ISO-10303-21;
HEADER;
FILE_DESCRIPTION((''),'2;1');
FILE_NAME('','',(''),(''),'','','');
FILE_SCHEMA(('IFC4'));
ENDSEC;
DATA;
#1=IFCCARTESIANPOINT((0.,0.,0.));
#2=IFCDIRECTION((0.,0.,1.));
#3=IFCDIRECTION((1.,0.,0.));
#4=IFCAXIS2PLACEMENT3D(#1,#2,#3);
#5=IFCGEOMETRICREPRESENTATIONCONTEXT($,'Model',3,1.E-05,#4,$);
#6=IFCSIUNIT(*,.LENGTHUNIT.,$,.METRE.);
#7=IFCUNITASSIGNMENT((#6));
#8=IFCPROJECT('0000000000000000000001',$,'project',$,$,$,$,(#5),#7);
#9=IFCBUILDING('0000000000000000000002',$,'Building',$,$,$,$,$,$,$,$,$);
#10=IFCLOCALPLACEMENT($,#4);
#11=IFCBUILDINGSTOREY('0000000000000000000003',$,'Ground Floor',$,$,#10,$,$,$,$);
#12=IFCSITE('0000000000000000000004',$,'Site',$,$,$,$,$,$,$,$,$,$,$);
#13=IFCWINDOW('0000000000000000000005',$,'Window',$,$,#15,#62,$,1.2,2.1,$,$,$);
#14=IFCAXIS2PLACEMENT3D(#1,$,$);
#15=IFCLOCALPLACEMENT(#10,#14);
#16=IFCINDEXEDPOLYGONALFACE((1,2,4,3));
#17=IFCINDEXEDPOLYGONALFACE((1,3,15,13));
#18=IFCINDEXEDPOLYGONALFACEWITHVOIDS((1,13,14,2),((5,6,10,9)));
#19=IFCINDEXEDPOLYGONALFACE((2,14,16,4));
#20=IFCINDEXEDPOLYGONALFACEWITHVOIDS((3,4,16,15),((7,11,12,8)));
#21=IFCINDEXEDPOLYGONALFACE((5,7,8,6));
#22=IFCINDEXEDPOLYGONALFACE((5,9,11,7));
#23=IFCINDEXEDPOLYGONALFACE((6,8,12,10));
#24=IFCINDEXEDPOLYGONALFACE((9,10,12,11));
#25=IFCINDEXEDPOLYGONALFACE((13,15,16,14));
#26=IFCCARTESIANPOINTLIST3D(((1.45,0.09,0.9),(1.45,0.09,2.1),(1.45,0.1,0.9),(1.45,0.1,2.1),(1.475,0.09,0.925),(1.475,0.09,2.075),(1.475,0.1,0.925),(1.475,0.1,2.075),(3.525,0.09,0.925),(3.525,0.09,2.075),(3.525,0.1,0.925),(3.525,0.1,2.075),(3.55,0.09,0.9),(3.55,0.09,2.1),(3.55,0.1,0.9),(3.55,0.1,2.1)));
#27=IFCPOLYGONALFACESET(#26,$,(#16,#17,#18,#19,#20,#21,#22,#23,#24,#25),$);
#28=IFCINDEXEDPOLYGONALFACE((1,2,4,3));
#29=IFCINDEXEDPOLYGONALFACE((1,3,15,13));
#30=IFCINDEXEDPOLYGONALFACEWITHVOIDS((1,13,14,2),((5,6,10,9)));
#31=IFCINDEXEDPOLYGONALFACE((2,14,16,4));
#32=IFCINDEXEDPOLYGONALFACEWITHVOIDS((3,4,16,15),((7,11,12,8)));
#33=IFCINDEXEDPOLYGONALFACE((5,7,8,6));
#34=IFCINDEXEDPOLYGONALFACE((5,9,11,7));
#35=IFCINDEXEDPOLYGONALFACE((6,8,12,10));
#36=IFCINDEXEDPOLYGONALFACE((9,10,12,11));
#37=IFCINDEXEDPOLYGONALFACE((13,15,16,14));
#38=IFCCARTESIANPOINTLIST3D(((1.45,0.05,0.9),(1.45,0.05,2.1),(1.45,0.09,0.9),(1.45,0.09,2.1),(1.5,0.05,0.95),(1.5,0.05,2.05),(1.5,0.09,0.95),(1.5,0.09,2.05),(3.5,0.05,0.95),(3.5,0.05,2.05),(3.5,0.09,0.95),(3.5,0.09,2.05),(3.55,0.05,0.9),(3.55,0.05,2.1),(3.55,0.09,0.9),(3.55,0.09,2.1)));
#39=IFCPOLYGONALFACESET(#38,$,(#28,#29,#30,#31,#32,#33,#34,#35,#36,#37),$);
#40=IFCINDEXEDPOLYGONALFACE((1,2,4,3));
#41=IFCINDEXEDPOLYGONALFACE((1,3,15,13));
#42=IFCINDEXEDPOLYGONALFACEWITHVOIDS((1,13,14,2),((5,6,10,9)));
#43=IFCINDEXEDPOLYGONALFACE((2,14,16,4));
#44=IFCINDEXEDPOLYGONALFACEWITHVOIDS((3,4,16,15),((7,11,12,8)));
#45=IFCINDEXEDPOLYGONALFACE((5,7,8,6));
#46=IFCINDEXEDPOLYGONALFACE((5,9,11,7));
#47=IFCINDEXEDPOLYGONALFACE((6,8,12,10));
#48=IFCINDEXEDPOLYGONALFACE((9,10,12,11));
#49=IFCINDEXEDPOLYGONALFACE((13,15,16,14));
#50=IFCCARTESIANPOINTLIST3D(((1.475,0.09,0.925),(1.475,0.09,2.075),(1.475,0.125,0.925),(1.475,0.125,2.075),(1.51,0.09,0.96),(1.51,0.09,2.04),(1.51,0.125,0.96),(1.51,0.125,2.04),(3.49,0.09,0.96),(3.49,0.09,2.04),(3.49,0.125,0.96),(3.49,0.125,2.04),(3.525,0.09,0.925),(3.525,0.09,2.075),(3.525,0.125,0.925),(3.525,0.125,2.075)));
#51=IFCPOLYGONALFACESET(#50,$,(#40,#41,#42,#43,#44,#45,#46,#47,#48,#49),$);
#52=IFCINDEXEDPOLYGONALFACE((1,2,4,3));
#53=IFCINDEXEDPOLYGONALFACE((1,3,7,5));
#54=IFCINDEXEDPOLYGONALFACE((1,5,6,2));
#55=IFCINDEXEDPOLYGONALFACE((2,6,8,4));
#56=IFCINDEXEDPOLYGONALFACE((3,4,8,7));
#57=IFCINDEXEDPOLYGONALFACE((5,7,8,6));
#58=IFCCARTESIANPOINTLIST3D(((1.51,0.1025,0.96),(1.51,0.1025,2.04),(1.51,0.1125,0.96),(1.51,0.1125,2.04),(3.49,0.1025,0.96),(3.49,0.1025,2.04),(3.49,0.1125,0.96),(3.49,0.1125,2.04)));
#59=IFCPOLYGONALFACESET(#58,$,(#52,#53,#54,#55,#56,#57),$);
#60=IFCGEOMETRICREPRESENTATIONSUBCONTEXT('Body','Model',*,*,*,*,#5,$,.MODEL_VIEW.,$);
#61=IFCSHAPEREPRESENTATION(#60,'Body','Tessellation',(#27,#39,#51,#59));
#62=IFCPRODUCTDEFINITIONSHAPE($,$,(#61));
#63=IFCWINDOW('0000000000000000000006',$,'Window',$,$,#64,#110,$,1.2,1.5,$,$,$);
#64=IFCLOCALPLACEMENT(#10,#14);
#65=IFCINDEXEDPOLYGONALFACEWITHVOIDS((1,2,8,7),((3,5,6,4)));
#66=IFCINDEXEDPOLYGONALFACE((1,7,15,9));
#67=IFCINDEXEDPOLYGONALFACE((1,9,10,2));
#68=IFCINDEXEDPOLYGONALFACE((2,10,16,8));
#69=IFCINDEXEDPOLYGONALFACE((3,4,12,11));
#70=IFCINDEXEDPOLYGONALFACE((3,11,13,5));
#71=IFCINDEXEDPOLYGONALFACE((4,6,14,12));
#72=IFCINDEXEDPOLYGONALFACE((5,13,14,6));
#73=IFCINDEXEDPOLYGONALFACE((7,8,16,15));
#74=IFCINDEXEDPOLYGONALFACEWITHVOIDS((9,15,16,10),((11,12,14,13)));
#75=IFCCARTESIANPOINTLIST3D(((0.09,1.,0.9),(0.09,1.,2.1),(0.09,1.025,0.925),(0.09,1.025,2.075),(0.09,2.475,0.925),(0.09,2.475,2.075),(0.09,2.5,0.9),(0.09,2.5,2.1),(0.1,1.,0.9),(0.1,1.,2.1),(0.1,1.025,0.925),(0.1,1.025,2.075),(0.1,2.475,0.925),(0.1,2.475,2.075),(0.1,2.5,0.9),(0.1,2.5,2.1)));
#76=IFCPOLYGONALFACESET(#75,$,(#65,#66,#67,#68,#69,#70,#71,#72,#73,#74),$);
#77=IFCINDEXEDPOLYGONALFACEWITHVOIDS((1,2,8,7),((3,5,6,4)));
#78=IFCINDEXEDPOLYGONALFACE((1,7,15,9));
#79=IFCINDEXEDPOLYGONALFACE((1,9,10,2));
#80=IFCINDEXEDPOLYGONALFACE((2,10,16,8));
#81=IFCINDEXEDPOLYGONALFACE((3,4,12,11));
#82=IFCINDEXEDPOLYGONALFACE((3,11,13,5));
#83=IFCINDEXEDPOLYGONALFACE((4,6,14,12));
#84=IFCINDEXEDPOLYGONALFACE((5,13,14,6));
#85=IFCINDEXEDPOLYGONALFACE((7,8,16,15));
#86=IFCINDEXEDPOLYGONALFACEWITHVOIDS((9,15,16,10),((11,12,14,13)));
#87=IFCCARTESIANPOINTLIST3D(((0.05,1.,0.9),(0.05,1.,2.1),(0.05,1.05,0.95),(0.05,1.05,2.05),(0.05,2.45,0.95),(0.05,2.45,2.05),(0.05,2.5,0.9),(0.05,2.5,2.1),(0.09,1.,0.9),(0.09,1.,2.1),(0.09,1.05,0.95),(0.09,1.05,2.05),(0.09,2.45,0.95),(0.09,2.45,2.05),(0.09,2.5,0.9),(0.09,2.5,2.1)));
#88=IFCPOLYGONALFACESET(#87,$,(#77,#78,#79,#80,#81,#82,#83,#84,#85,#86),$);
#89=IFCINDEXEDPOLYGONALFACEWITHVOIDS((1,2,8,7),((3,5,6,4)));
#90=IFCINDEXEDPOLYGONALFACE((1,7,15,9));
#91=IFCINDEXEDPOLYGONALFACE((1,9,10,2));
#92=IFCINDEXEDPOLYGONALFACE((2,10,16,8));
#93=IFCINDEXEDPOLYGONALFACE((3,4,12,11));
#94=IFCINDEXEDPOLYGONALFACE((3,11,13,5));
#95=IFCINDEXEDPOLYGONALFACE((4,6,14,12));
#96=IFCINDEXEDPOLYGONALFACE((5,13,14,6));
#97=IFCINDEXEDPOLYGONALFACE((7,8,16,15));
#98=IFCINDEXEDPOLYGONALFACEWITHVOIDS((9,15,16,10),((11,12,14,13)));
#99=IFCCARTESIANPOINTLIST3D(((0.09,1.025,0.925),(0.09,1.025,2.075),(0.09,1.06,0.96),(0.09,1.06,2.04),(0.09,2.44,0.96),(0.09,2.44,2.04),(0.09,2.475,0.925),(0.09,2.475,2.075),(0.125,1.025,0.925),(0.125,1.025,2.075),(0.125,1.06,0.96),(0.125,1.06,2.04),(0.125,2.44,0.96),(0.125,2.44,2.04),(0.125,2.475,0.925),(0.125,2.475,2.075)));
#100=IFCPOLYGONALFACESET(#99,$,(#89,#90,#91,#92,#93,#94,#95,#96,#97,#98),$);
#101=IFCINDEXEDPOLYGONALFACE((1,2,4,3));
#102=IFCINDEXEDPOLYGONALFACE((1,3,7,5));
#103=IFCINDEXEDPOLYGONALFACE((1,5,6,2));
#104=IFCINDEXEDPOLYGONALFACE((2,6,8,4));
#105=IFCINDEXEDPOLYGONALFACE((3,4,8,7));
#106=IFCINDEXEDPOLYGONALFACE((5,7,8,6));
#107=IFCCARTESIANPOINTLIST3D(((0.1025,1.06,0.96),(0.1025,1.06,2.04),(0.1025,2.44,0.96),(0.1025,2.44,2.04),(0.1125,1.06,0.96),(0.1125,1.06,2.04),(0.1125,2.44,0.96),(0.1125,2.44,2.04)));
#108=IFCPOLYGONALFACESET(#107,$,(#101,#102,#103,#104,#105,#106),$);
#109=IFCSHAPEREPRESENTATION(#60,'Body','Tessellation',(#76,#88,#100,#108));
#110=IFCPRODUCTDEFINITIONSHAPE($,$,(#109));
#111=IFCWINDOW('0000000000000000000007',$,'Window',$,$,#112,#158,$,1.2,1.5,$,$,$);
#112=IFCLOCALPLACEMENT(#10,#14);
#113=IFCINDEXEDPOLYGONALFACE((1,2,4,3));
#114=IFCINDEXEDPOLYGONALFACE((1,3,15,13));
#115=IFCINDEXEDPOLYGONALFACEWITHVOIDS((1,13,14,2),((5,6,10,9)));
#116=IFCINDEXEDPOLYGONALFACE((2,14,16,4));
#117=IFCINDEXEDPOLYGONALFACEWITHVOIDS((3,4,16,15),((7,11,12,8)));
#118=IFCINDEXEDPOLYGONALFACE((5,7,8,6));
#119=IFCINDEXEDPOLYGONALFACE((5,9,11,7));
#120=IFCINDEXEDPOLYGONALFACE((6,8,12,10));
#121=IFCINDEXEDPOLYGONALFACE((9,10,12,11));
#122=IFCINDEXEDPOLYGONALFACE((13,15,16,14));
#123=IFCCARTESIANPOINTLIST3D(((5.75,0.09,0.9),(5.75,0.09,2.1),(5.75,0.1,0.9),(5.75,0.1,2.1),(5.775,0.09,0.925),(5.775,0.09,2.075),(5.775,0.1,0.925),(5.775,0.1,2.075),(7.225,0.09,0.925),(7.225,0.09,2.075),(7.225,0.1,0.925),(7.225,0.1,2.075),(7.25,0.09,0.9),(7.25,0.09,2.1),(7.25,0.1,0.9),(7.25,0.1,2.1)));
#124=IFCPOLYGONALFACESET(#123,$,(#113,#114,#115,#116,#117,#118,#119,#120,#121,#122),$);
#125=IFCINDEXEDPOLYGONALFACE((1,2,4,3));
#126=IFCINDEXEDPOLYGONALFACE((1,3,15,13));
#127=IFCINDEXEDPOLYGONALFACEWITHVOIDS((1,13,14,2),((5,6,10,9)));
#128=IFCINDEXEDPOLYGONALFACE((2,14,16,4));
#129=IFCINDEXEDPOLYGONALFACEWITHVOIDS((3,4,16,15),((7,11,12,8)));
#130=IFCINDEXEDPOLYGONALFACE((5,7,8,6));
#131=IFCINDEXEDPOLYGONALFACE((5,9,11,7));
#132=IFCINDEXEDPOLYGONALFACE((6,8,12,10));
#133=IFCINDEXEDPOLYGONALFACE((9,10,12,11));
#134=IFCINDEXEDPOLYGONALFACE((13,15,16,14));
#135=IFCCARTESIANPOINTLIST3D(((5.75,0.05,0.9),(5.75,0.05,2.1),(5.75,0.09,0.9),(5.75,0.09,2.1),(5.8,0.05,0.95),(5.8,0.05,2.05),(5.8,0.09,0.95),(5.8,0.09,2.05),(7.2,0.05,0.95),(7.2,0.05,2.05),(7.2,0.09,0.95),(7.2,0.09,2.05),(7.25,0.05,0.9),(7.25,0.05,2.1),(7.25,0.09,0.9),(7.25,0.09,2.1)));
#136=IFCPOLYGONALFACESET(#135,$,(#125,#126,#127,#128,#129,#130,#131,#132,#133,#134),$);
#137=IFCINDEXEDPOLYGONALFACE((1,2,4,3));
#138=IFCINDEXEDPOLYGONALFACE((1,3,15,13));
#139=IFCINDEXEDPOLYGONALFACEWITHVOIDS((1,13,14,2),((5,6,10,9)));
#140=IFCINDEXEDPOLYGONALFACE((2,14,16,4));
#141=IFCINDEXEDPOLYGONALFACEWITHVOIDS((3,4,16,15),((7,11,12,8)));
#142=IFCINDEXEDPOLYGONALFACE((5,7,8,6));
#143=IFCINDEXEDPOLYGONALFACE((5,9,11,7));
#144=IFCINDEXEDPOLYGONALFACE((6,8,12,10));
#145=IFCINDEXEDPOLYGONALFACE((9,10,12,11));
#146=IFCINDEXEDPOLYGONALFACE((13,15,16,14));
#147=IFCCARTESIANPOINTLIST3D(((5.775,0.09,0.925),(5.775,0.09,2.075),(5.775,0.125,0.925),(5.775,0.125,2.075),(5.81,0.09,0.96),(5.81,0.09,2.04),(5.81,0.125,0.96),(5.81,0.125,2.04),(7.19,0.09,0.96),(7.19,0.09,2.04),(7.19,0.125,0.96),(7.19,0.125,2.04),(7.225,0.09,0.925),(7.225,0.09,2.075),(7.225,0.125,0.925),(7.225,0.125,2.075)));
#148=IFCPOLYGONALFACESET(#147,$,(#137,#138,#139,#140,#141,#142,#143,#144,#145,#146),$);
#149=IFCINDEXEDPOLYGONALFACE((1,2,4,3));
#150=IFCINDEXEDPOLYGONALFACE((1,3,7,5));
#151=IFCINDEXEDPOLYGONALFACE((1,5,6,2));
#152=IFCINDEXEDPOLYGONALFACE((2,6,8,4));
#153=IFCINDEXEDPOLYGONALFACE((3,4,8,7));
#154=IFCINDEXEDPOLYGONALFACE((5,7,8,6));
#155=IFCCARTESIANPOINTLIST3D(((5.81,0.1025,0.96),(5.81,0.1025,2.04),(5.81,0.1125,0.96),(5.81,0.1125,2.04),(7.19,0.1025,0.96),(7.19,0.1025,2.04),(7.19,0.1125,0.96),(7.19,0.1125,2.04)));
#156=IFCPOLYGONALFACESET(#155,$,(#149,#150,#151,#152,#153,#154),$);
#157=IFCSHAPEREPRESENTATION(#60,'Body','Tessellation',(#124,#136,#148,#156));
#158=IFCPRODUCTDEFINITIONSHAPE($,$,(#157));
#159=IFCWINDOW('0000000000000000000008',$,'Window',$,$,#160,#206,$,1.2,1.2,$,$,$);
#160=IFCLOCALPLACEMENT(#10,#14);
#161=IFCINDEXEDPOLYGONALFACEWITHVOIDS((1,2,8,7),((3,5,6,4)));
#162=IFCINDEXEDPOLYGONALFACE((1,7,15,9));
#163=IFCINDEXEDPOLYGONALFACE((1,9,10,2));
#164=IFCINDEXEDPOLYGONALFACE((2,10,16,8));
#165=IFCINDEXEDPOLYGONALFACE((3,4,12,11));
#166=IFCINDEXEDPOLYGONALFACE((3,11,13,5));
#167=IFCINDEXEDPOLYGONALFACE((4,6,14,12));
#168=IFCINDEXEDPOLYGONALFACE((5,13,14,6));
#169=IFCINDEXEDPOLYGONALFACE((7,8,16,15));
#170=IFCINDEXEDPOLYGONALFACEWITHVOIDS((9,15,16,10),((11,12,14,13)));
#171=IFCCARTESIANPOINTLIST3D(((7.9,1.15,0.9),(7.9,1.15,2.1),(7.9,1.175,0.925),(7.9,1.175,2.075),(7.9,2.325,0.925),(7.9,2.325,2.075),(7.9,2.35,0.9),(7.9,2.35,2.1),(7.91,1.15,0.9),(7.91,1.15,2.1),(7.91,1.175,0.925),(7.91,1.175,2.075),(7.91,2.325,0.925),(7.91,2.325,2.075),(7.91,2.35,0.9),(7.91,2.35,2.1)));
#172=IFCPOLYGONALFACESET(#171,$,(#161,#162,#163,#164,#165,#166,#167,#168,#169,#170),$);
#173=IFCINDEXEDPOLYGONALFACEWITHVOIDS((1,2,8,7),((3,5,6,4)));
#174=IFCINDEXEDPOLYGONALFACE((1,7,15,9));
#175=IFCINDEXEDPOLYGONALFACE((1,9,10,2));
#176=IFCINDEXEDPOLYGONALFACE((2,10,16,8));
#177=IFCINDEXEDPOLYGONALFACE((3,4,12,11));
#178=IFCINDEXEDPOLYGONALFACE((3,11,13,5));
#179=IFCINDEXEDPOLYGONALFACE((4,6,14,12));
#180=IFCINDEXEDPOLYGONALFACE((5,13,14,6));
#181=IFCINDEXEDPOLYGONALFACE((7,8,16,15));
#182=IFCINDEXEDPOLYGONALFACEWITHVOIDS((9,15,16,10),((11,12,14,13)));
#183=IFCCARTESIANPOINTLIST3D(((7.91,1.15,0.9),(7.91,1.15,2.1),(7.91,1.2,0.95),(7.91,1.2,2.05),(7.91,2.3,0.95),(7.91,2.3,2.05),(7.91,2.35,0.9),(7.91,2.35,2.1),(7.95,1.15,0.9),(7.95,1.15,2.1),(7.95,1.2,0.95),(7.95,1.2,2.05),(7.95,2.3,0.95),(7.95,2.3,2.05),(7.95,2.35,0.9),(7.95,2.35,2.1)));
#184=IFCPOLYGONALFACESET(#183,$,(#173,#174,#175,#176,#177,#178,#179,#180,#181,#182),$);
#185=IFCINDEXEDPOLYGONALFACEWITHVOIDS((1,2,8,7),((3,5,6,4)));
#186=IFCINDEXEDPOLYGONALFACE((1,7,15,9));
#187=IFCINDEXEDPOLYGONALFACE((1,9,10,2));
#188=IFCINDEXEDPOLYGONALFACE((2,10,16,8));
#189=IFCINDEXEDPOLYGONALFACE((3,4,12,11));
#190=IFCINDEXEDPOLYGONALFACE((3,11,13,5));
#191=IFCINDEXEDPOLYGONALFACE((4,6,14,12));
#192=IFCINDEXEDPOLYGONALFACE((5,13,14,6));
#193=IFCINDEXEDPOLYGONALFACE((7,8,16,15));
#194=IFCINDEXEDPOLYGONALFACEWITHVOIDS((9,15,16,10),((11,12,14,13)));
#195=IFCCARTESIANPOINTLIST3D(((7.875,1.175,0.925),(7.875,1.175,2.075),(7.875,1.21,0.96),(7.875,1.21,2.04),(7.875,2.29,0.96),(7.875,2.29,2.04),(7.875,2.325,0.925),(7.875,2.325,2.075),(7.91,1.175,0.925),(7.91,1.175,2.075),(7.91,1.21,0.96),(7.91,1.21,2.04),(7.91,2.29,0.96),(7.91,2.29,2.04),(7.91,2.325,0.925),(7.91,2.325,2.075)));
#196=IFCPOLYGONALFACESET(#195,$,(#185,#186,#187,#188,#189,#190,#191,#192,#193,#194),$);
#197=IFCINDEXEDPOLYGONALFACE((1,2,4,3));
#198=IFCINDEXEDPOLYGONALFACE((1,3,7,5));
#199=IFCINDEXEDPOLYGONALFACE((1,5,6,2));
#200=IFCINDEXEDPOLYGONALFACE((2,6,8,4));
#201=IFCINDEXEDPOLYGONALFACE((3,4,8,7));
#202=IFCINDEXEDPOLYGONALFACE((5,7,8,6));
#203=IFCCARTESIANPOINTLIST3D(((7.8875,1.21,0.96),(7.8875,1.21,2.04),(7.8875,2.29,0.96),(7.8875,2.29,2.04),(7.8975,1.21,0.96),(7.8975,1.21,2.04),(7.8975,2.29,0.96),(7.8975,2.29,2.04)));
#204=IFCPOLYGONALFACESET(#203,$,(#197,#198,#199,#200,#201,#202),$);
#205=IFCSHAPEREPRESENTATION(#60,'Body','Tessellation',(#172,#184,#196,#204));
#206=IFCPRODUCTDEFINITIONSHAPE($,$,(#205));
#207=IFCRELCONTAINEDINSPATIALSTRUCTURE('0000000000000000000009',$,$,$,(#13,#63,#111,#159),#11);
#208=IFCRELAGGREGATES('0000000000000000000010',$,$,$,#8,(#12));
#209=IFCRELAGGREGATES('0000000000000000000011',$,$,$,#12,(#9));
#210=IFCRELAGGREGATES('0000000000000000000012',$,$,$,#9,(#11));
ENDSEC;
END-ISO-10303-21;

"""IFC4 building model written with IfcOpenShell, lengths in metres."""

from ifc_helpers import new_model, si_unit, frame, origin_with_axes, place, context, subcontext, project, spatial, line, indexed_curve, outline, extrude, element, save


model = new_model("IFC4")

# Units and contexts
model_context = context("Model", 3, precision=1e-05, world=origin_with_axes())
body_context = subcontext(model_context, "Body", "Model", "MODEL_VIEW")
ifc_project = project(units=[si_unit("LENGTHUNIT", "METRE")], contexts=[model_context])

# Site, building, storey
site = spatial("IfcSite", under=ifc_project, Name="Site")
building = spatial("IfcBuilding", under=site, Name="Building")
storey_placement = place(None, origin_with_axes())
storey = spatial("IfcBuildingStorey", under=building, at=storey_placement, Name="Ground Floor")

# Windows
window_1_placement = place(storey_placement, frame((1.45, 0.0, 0.9), z_axis=(0.0, 0.0, 1.0), x_axis=(1.0, 0.0, 0.0)))
element("IfcWindow", 1, at=window_1_placement, inside=storey, Name="Window", OverallHeight=1.2, OverallWidth=2.1, context=body_context, shape_type="SweptSolid", body=[
    extrude(outline(indexed_curve([(0.0, 0.0), (2.1, 0.0), (2.1, 1.2), (0.0, 1.2)], segments=[line(1, 2, 3, 4, 1)]), holes=[indexed_curve([(0.025, 0.025), (2.075, 0.025), (2.075, 1.175), (0.025, 1.175)], segments=[line(1, 2, 3, 4, 1)])]), frame((0.0, 0.09, 0.0), z_axis=(0.0, -1.0, 0.0), x_axis=(1.0, 0.0, 0.0)), (0.0, 0.0, -1.0), 0.01),
    extrude(outline(indexed_curve([(0.0, 0.0), (2.1, 0.0), (2.1, 1.2), (0.0, 1.2)], segments=[line(1, 2, 3, 4, 1)]), holes=[indexed_curve([(0.05, 0.05), (2.05, 0.05), (2.05, 1.15), (0.05, 1.15)], segments=[line(1, 2, 3, 4, 1)])]), frame((0.0, 0.05, 0.0), z_axis=(0.0, -1.0, 0.0), x_axis=(1.0, 0.0, 0.0)), (0.0, 0.0, -1.0), 0.04),
    extrude(outline(indexed_curve([(0.0, 0.0), (2.05, 0.0), (2.05, 1.15), (0.0, 1.15)], segments=[line(1, 2, 3, 4, 1)]), holes=[indexed_curve([(0.035, 0.035), (2.015, 0.035), (2.015, 1.115), (0.035, 1.115)], segments=[line(1, 2, 3, 4, 1)])]), frame((0.025, 0.09, 0.025), z_axis=(0.0, -1.0, 0.0), x_axis=(1.0, 0.0, 0.0)), (0.0, 0.0, -1.0), 0.035),
    extrude(outline(indexed_curve([(0.035, 0.035), (2.015, 0.035), (2.015, 1.115), (0.035, 1.115)], segments=[line(1, 2, 3, 4, 1)])), frame((0.025, 0.1025, 0.025), z_axis=(0.0, -1.0, 0.0), x_axis=(1.0, 0.0, 0.0)), (0.0, 0.0, -1.0), 0.01),
])
for number, where, z_axis, x_axis, name in (
    (2, (0.0, 2.5, 0.9), (0.0, 0.0, 1.0), (0.0, -1.0, 0.0), "Window"),
    (3, (5.75, 0.0, 0.9), (0.0, 0.0, 1.0), (1.0, 0.0, 0.0), "Window"),
):
    element("IfcWindow", number, at=place(storey_placement, frame(where, z_axis=z_axis, x_axis=x_axis)), inside=storey, Name=name, OverallHeight=1.2, OverallWidth=1.5, context=body_context, shape_type="SweptSolid", body=[
        extrude(outline(indexed_curve([(0.0, 0.0), (1.5, 0.0), (1.5, 1.2), (0.0, 1.2)], segments=[line(1, 2, 3, 4, 1)]), holes=[indexed_curve([(0.025, 0.025), (1.475, 0.025), (1.475, 1.175), (0.025, 1.175)], segments=[line(1, 2, 3, 4, 1)])]), frame((0.0, 0.09, 0.0), z_axis=(0.0, -1.0, 0.0), x_axis=(1.0, 0.0, 0.0)), (0.0, 0.0, -1.0), 0.01),
        extrude(outline(indexed_curve([(0.0, 0.0), (1.5, 0.0), (1.5, 1.2), (0.0, 1.2)], segments=[line(1, 2, 3, 4, 1)]), holes=[indexed_curve([(0.05, 0.05), (1.45, 0.05), (1.45, 1.15), (0.05, 1.15)], segments=[line(1, 2, 3, 4, 1)])]), frame((0.0, 0.05, 0.0), z_axis=(0.0, -1.0, 0.0), x_axis=(1.0, 0.0, 0.0)), (0.0, 0.0, -1.0), 0.04),
        extrude(outline(indexed_curve([(0.0, 0.0), (1.45, 0.0), (1.45, 1.15), (0.0, 1.15)], segments=[line(1, 2, 3, 4, 1)]), holes=[indexed_curve([(0.035, 0.035), (1.415, 0.035), (1.415, 1.115), (0.035, 1.115)], segments=[line(1, 2, 3, 4, 1)])]), frame((0.025, 0.09, 0.025), z_axis=(0.0, -1.0, 0.0), x_axis=(1.0, 0.0, 0.0)), (0.0, 0.0, -1.0), 0.035),
        extrude(outline(indexed_curve([(0.035, 0.035), (1.415, 0.035), (1.415, 1.115), (0.035, 1.115)], segments=[line(1, 2, 3, 4, 1)])), frame((0.025, 0.1025, 0.025), z_axis=(0.0, -1.0, 0.0), x_axis=(1.0, 0.0, 0.0)), (0.0, 0.0, -1.0), 0.01),
    ])
window_2_placement = place(storey_placement, frame((8.0, 1.15, 0.9), z_axis=(0.0, 0.0, 1.0), x_axis=(0.0, 1.0, 0.0)))
element("IfcWindow", 4, at=window_2_placement, inside=storey, Name="Window", OverallHeight=1.2, OverallWidth=1.2, context=body_context, shape_type="SweptSolid", body=[
    extrude(outline(indexed_curve([(0.0, 0.0), (1.2, 0.0), (1.2, 1.2), (0.0, 1.2)], segments=[line(1, 2, 3, 4, 1)]), holes=[indexed_curve([(0.025, 0.025), (1.175, 0.025), (1.175, 1.175), (0.025, 1.175)], segments=[line(1, 2, 3, 4, 1)])]), frame((0.0, 0.09, 0.0), z_axis=(0.0, -1.0, 0.0), x_axis=(1.0, 0.0, 0.0)), (0.0, 0.0, -1.0), 0.01),
    extrude(outline(indexed_curve([(0.0, 0.0), (1.2, 0.0), (1.2, 1.2), (0.0, 1.2)], segments=[line(1, 2, 3, 4, 1)]), holes=[indexed_curve([(0.05, 0.05), (1.15, 0.05), (1.15, 1.15), (0.05, 1.15)], segments=[line(1, 2, 3, 4, 1)])]), frame((0.0, 0.05, 0.0), z_axis=(0.0, -1.0, 0.0), x_axis=(1.0, 0.0, 0.0)), (0.0, 0.0, -1.0), 0.04),
    extrude(outline(indexed_curve([(0.0, 0.0), (1.15, 0.0), (1.15, 1.15), (0.0, 1.15)], segments=[line(1, 2, 3, 4, 1)]), holes=[indexed_curve([(0.035, 0.035), (1.115, 0.035), (1.115, 1.115), (0.035, 1.115)], segments=[line(1, 2, 3, 4, 1)])]), frame((0.025, 0.09, 0.025), z_axis=(0.0, -1.0, 0.0), x_axis=(1.0, 0.0, 0.0)), (0.0, 0.0, -1.0), 0.035),
    extrude(outline(indexed_curve([(0.035, 0.035), (1.115, 0.035), (1.115, 1.115), (0.035, 1.115)], segments=[line(1, 2, 3, 4, 1)])), frame((0.025, 0.1025, 0.025), z_axis=(0.0, -1.0, 0.0), x_axis=(1.0, 0.0, 0.0)), (0.0, 0.0, -1.0), 0.01),
])

save(model, "model.ifc")
